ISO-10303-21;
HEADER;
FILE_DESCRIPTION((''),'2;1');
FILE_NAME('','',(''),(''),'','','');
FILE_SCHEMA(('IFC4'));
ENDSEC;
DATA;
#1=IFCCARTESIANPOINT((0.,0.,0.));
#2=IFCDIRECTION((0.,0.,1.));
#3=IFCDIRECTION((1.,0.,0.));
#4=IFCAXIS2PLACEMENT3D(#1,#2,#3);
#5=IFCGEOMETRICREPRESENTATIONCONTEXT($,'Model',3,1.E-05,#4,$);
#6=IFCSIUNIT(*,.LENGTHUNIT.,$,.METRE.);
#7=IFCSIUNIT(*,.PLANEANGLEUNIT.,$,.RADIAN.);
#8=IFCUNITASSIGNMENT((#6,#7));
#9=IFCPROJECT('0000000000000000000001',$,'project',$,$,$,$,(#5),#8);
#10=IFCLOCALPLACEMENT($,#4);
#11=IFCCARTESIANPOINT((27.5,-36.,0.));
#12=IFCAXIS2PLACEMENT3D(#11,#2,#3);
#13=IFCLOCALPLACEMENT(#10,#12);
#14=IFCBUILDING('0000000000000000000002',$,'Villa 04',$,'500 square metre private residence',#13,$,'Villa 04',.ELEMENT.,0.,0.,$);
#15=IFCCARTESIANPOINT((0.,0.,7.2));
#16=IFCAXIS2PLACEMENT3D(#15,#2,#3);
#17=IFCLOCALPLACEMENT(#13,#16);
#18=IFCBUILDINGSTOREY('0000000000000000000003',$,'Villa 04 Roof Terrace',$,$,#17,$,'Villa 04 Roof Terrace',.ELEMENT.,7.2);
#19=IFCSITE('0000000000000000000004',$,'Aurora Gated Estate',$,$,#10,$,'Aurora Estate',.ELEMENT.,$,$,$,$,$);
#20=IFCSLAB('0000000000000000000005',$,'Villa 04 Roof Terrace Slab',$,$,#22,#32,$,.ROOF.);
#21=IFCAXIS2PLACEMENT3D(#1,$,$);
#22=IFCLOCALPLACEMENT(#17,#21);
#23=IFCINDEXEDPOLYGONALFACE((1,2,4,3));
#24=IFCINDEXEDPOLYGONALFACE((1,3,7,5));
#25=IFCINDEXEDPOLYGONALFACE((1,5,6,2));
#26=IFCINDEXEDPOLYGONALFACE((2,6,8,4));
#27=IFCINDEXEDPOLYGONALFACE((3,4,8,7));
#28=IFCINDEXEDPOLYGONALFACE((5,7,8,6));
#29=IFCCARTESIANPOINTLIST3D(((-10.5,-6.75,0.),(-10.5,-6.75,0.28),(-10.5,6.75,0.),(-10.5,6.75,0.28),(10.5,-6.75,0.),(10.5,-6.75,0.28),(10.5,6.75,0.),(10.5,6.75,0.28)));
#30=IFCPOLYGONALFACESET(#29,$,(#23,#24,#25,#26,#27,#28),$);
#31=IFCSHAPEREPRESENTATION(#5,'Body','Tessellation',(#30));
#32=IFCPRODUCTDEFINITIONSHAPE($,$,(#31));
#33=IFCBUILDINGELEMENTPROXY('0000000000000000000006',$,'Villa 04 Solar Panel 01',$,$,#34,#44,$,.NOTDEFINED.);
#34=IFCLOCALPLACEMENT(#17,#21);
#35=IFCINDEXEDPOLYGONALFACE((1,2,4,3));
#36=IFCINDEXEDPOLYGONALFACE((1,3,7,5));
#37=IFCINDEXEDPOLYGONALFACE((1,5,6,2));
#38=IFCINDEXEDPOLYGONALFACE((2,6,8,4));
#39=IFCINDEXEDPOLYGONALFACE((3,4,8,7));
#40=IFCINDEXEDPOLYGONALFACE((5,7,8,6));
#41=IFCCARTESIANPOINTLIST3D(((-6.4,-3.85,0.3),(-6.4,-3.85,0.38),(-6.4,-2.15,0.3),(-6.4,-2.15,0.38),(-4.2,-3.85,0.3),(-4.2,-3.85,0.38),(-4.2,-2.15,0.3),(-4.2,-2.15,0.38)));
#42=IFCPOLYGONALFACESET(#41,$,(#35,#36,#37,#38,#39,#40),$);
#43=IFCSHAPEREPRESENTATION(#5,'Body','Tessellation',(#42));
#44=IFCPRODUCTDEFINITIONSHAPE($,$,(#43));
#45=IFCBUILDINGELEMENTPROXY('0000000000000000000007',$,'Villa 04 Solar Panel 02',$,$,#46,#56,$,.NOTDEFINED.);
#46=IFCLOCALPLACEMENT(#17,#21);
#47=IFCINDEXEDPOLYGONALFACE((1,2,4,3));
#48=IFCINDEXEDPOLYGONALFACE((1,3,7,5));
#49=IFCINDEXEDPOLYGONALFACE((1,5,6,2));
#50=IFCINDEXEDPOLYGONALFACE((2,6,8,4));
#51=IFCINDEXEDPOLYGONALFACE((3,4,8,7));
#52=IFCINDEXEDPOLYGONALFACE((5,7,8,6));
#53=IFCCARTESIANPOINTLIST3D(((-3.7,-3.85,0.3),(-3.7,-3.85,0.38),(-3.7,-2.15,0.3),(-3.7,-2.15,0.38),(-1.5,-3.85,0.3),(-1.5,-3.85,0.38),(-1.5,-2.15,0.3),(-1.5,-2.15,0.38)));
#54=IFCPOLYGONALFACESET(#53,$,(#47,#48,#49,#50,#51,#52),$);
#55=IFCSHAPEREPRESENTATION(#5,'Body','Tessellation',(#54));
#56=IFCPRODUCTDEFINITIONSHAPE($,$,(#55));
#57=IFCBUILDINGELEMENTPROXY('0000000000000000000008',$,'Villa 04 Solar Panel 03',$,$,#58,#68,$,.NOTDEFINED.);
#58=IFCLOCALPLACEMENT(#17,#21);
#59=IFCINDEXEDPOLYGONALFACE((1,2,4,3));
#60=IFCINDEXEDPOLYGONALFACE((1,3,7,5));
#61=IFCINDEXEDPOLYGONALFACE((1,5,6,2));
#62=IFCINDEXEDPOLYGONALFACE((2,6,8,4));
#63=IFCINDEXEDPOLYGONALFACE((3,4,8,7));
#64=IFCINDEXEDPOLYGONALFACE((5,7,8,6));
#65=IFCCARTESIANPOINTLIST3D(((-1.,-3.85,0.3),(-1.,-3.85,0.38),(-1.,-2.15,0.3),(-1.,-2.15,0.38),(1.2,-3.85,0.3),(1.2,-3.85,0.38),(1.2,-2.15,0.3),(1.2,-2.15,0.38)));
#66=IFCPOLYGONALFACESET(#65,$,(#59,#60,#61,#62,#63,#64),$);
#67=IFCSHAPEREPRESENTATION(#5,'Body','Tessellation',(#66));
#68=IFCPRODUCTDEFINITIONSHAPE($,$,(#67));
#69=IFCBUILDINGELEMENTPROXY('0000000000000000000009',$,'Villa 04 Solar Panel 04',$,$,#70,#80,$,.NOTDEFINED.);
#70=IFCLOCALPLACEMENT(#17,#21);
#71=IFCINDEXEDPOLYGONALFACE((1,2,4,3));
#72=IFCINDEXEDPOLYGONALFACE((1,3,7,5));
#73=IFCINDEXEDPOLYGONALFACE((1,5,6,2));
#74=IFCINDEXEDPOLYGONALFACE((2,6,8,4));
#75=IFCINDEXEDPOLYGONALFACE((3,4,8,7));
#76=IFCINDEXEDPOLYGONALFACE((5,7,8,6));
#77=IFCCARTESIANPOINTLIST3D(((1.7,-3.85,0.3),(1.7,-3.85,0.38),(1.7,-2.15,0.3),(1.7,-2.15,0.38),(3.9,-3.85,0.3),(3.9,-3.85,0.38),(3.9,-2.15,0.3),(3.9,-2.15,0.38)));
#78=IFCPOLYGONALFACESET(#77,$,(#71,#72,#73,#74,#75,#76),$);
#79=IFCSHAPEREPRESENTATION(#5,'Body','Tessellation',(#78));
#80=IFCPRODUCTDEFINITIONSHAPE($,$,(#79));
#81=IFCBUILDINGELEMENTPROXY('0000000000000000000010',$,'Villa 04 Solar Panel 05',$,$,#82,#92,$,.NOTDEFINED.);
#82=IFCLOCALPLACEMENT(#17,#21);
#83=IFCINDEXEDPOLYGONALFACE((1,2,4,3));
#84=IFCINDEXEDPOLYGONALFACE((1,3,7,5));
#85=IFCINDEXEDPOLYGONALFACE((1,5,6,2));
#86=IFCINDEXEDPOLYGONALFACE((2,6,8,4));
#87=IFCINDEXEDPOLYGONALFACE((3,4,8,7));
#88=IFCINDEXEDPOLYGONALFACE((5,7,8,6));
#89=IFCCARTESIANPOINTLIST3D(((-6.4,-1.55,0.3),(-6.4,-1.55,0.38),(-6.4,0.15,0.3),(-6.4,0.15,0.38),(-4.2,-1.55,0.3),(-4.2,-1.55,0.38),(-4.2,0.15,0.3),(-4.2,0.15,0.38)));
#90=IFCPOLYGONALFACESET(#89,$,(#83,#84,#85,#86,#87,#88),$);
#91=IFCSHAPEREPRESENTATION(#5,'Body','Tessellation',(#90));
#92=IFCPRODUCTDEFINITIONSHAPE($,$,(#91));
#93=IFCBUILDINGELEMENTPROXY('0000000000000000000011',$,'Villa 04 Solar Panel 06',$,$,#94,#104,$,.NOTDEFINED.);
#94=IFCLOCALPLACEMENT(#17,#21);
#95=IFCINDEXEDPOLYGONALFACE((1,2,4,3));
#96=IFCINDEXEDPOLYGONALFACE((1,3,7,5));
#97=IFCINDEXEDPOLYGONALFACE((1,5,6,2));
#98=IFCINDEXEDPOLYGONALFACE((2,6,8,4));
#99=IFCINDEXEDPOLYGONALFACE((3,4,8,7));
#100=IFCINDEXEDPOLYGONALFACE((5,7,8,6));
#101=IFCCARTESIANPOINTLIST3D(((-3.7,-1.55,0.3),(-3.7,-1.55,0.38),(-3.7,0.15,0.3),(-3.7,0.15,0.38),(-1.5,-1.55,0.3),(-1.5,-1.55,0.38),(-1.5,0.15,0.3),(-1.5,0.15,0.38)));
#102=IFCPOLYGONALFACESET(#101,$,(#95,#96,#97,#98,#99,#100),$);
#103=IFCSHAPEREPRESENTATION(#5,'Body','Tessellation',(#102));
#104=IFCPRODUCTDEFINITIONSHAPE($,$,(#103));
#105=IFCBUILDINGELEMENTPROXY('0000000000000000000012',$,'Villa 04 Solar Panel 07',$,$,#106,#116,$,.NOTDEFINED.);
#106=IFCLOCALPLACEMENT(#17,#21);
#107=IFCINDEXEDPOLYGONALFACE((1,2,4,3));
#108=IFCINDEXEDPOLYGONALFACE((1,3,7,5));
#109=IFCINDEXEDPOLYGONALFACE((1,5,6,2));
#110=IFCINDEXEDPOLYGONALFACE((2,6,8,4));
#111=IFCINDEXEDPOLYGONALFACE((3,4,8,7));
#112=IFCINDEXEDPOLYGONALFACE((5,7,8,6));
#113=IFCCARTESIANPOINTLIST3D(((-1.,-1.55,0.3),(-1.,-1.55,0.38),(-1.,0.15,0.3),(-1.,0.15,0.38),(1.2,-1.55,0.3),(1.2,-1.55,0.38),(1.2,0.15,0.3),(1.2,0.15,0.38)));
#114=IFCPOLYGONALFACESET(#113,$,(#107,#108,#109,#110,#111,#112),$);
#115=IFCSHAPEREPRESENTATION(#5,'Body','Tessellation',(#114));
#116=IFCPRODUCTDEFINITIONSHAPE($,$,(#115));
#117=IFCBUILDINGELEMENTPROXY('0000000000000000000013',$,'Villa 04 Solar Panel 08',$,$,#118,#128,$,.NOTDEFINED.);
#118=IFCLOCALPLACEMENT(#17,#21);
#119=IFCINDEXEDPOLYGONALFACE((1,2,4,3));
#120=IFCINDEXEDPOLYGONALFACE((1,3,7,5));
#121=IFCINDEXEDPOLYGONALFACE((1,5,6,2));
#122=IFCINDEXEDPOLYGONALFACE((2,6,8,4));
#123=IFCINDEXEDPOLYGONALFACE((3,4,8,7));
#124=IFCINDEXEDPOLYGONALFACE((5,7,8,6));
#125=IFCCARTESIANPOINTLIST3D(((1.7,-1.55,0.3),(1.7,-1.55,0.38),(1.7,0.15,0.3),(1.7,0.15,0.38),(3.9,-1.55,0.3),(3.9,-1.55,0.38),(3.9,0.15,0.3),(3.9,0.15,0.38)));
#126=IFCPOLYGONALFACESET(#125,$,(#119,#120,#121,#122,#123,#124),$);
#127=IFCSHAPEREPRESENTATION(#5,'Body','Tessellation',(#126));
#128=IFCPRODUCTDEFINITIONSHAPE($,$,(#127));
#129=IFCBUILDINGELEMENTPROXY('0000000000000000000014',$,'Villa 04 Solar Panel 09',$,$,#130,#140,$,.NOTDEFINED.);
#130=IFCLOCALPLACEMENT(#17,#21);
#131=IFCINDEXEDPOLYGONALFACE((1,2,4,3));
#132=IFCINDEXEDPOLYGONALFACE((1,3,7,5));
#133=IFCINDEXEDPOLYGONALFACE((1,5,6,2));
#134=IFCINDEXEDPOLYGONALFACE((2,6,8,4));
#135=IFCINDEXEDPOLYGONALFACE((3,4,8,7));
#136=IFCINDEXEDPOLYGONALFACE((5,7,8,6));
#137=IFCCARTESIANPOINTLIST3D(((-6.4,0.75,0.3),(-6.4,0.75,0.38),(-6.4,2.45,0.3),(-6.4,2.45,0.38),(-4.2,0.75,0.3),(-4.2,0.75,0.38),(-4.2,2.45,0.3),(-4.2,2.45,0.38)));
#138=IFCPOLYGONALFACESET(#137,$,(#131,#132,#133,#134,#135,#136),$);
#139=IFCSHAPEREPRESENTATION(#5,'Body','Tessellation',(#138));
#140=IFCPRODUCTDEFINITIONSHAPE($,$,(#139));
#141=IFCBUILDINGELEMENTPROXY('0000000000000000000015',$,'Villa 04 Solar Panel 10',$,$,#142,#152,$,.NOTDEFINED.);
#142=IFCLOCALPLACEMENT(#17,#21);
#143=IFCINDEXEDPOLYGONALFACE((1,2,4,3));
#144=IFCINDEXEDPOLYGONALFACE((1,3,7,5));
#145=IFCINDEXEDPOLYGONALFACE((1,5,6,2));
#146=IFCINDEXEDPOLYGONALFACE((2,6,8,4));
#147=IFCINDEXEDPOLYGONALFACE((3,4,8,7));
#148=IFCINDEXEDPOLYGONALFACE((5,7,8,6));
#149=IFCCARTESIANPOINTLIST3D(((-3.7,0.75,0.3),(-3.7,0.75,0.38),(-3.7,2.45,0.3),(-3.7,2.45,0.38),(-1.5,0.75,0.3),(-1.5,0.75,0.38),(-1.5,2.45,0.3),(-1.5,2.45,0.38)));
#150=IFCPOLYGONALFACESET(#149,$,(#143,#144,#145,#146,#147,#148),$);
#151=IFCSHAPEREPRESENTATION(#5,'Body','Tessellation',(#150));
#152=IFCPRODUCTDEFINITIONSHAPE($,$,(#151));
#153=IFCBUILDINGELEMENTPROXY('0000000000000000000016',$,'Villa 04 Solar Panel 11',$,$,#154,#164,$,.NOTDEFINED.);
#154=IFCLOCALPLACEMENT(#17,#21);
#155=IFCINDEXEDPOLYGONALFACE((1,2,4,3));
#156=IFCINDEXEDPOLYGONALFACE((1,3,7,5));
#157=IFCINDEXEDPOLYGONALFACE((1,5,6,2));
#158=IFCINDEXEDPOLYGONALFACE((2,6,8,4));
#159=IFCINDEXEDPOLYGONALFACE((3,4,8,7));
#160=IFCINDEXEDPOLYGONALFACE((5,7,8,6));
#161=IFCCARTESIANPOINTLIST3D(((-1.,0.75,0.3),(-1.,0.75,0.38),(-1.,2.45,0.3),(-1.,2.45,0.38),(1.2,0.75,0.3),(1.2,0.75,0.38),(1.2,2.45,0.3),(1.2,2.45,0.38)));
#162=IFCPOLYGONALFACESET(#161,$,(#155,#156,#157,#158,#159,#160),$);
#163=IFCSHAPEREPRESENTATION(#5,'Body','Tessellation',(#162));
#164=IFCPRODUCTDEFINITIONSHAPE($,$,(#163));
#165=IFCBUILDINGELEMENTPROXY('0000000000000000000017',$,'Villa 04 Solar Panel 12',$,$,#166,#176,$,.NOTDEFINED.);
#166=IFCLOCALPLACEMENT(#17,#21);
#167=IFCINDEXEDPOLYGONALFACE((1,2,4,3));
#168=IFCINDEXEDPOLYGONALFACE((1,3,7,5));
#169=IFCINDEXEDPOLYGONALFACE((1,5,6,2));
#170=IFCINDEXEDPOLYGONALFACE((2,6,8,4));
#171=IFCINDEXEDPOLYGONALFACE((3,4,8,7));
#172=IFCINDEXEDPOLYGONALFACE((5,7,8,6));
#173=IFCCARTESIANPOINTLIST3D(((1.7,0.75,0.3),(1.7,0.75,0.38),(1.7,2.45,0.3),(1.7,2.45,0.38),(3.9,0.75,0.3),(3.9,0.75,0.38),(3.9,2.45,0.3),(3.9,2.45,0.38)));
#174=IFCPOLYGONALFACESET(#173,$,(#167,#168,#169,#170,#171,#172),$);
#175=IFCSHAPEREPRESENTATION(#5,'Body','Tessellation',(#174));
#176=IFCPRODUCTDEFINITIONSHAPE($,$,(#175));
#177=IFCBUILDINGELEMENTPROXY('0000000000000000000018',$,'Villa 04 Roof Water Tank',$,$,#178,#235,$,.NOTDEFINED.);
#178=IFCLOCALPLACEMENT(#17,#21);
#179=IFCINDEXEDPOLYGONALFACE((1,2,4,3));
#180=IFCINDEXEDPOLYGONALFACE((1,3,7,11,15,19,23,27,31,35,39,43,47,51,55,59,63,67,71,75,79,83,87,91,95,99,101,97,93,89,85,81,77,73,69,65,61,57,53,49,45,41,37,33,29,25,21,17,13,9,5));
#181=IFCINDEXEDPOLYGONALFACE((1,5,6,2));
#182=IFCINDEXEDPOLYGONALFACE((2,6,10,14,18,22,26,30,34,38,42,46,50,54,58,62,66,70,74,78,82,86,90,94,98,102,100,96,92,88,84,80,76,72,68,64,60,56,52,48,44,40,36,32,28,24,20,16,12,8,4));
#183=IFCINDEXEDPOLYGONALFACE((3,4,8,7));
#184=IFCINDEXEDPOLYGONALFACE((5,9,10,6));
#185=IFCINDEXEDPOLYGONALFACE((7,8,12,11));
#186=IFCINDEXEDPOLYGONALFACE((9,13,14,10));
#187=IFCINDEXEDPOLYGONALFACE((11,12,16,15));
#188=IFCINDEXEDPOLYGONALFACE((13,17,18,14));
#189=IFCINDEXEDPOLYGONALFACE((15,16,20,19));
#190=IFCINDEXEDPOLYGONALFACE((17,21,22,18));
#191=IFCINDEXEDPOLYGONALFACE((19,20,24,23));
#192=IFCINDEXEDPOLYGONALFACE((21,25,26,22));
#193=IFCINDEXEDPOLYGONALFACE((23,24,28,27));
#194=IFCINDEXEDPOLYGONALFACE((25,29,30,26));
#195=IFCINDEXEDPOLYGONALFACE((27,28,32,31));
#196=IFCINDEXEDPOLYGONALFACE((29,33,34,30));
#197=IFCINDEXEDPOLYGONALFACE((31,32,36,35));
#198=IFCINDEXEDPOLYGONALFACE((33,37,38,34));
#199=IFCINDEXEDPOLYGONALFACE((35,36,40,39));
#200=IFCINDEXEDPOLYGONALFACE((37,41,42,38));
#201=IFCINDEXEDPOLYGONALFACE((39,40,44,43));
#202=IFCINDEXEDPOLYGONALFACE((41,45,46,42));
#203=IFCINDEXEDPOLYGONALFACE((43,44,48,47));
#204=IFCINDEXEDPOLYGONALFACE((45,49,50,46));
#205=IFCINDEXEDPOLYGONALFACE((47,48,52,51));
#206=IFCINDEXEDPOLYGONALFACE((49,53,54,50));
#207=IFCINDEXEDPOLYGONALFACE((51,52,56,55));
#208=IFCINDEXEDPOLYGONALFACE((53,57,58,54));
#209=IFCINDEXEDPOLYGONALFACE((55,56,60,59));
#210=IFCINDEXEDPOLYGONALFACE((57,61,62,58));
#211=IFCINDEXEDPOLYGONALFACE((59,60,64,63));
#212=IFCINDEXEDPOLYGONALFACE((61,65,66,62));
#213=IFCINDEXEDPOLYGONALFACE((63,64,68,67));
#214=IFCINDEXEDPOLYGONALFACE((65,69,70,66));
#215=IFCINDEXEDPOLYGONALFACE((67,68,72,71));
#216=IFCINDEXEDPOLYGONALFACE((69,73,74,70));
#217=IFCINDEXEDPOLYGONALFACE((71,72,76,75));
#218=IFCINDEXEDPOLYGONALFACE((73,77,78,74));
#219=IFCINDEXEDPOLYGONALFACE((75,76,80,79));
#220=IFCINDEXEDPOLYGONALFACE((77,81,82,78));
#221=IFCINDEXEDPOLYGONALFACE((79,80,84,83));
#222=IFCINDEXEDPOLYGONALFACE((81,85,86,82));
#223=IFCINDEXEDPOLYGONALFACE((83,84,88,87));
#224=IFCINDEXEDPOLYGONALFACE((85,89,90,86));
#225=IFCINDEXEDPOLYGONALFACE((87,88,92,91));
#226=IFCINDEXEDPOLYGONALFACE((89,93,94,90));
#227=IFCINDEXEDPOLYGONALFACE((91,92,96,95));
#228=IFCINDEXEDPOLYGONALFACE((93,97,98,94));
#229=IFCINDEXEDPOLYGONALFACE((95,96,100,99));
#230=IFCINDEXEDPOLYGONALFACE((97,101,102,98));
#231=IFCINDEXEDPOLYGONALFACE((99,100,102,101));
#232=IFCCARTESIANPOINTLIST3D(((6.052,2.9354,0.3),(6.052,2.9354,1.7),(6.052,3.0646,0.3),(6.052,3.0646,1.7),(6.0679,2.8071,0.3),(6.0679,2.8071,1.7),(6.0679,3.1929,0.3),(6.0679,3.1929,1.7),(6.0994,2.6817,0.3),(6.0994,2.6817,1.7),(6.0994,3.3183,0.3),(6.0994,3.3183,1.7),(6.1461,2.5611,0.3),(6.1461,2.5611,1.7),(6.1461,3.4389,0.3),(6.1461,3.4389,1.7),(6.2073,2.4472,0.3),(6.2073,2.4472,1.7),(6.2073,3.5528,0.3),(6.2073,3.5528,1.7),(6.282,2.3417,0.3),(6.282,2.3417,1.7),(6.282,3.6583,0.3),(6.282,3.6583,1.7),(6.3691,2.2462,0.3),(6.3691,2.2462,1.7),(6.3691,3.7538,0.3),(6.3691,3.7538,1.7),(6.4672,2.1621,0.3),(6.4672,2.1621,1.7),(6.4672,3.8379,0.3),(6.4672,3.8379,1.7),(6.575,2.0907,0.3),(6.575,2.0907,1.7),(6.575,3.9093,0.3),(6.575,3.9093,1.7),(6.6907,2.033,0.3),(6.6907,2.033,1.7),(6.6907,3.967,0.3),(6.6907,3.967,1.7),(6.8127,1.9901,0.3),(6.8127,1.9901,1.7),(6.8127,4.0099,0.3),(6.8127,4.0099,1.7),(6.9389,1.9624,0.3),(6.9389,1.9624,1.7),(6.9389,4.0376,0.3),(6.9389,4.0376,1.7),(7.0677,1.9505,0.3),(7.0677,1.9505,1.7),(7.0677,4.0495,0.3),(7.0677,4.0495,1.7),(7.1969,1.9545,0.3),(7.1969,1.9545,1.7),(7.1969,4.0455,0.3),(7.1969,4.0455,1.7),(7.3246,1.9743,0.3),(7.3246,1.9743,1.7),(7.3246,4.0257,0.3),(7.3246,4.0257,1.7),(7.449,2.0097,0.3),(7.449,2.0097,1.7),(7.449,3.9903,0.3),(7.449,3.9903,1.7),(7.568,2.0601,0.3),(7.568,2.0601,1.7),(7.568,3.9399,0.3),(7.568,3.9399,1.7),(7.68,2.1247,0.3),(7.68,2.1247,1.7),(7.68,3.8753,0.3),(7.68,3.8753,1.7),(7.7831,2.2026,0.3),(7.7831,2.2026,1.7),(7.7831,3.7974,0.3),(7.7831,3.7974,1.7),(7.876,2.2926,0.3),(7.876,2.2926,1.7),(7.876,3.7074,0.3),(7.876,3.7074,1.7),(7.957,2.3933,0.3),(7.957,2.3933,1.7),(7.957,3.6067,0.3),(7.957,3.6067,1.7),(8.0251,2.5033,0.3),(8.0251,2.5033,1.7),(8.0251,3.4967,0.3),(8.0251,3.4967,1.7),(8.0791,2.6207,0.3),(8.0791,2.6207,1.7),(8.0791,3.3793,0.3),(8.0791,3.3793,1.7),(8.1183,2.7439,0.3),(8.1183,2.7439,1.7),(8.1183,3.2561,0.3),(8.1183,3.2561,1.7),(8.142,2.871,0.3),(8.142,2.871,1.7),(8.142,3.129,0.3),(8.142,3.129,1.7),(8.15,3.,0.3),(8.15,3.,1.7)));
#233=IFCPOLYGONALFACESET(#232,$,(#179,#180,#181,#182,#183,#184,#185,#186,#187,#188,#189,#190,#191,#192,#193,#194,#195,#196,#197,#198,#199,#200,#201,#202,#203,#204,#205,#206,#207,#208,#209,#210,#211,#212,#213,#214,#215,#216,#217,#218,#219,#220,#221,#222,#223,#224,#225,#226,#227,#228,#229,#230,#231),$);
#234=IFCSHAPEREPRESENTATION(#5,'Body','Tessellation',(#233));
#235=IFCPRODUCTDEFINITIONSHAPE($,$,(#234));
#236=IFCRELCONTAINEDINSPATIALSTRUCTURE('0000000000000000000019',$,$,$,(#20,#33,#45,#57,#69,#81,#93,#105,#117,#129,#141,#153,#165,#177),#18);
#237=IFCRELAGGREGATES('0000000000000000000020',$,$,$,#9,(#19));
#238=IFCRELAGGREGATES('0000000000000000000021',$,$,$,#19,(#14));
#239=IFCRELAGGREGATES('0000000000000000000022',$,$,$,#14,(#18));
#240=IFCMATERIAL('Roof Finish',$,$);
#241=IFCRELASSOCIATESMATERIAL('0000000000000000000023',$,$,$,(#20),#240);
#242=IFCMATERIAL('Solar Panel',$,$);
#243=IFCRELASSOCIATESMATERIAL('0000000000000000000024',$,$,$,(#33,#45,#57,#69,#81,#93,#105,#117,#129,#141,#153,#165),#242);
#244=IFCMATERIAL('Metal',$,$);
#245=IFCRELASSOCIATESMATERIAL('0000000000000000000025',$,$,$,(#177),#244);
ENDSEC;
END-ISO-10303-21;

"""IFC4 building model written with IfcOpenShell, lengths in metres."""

from ifc_helpers import new_model, si_unit, frame, origin_with_axes, origin_2d_with_axis, place, context, project, spatial, rectangle, circle, extrude, material, element, save


model = new_model("IFC4")

# Units and contexts
model_context = context("Model", 3, precision=1e-05, world=origin_with_axes())
ifc_project = project(units=[si_unit("LENGTHUNIT", "METRE"), si_unit("PLANEANGLEUNIT", "RADIAN")], contexts=[model_context])

# Site, building, storey
site_placement = place(None, origin_with_axes())
site = spatial("IfcSite", under=ifc_project, at=site_placement, Name="Aurora Gated Estate", LongName="Aurora Estate", CompositionType="ELEMENT")
building_placement = place(site_placement, frame((27.5, -36.0, 0.0), z_axis=(0.0, 0.0, 1.0), x_axis=(1.0, 0.0, 0.0)))
building = spatial("IfcBuilding", under=site, at=building_placement, Name="Villa 04", ObjectType="500 square metre private residence", LongName="Villa 04", CompositionType="ELEMENT", ElevationOfRefHeight=0.0, ElevationOfTerrain=0.0)
storey_placement = place(building_placement, frame((0.0, 0.0, 7.2), z_axis=(0.0, 0.0, 1.0), x_axis=(1.0, 0.0, 0.0)))
storey = spatial("IfcBuildingStorey", under=building, at=storey_placement, Name="Villa 04 Roof Terrace", LongName="Villa 04 Roof Terrace", CompositionType="ELEMENT", Elevation=7.2)

# Slab
ifc_material_1 = material(Name="Roof Finish")
slab_placement = place(storey_placement, origin_with_axes())
element("IfcSlab", 1, at=slab_placement, inside=storey, material=ifc_material_1, Name="Villa 04 Roof Terrace Slab", PredefinedType="ROOF", context=model_context, shape_type="SweptSolid", body=[
    extrude(rectangle(XDim=21.0, YDim=13.5, at=origin_2d_with_axis()), origin_with_axes(), (0.0, 0.0, 1.0), 0.28),
])

# Building element proxies
ifc_material_2 = material(Name="Solar Panel")
for number, where, z_axis, x_axis, name in (
    (2, (-5.3, -3.0, 0.3), (0.0, 0.0, 1.0), (1.0, 0.0, 0.0), "Villa 04 Solar Panel 01"),
    (3, (-2.6, -3.0, 0.3), (0.0, 0.0, 1.0), (1.0, 0.0, 0.0), "Villa 04 Solar Panel 02"),
    (4, (0.1, -3.0, 0.3), (0.0, 0.0, 1.0), (1.0, 0.0, 0.0), "Villa 04 Solar Panel 03"),
    (5, (2.8, -3.0, 0.3), (0.0, 0.0, 1.0), (1.0, 0.0, 0.0), "Villa 04 Solar Panel 04"),
    (6, (-5.3, -0.7, 0.3), (0.0, 0.0, 1.0), (1.0, 0.0, 0.0), "Villa 04 Solar Panel 05"),
    (7, (-2.6, -0.7, 0.3), (0.0, 0.0, 1.0), (1.0, 0.0, 0.0), "Villa 04 Solar Panel 06"),
    (8, (0.1, -0.7, 0.3), (0.0, 0.0, 1.0), (1.0, 0.0, 0.0), "Villa 04 Solar Panel 07"),
    (9, (2.8, -0.7, 0.3), (0.0, 0.0, 1.0), (1.0, 0.0, 0.0), "Villa 04 Solar Panel 08"),
    (10, (-5.3, 1.6, 0.3), (0.0, 0.0, 1.0), (1.0, 0.0, 0.0), "Villa 04 Solar Panel 09"),
    (11, (-2.6, 1.6, 0.3), (0.0, 0.0, 1.0), (1.0, 0.0, 0.0), "Villa 04 Solar Panel 10"),
    (12, (0.1, 1.6, 0.3), (0.0, 0.0, 1.0), (1.0, 0.0, 0.0), "Villa 04 Solar Panel 11"),
    (13, (2.8, 1.6, 0.3), (0.0, 0.0, 1.0), (1.0, 0.0, 0.0), "Villa 04 Solar Panel 12"),
):
    element("IfcBuildingElementProxy", number, at=place(storey_placement, frame(where, z_axis=z_axis, x_axis=x_axis)), inside=storey, material=ifc_material_2, Name=name, PredefinedType="NOTDEFINED", context=model_context, shape_type="SweptSolid", body=[
        extrude(rectangle(XDim=2.2, YDim=1.7, at=origin_2d_with_axis()), origin_with_axes(), (0.0, 0.0, 1.0), 0.08),
    ])
ifc_material_3 = material(Name="Metal")
proxy_1_placement = place(storey_placement, frame((7.1, 3.0, 0.3), z_axis=(0.0, 0.0, 1.0), x_axis=(1.0, 0.0, 0.0)))
element("IfcBuildingElementProxy", 14, at=proxy_1_placement, inside=storey, material=ifc_material_3, Name="Villa 04 Roof Water Tank", PredefinedType="NOTDEFINED", context=model_context, shape_type="SweptSolid", body=[
    extrude(circle(Radius=1.05, at=origin_2d_with_axis()), origin_with_axes(), (0.0, 0.0, 1.0), 1.4),
])

save(model, "model.ifc")
